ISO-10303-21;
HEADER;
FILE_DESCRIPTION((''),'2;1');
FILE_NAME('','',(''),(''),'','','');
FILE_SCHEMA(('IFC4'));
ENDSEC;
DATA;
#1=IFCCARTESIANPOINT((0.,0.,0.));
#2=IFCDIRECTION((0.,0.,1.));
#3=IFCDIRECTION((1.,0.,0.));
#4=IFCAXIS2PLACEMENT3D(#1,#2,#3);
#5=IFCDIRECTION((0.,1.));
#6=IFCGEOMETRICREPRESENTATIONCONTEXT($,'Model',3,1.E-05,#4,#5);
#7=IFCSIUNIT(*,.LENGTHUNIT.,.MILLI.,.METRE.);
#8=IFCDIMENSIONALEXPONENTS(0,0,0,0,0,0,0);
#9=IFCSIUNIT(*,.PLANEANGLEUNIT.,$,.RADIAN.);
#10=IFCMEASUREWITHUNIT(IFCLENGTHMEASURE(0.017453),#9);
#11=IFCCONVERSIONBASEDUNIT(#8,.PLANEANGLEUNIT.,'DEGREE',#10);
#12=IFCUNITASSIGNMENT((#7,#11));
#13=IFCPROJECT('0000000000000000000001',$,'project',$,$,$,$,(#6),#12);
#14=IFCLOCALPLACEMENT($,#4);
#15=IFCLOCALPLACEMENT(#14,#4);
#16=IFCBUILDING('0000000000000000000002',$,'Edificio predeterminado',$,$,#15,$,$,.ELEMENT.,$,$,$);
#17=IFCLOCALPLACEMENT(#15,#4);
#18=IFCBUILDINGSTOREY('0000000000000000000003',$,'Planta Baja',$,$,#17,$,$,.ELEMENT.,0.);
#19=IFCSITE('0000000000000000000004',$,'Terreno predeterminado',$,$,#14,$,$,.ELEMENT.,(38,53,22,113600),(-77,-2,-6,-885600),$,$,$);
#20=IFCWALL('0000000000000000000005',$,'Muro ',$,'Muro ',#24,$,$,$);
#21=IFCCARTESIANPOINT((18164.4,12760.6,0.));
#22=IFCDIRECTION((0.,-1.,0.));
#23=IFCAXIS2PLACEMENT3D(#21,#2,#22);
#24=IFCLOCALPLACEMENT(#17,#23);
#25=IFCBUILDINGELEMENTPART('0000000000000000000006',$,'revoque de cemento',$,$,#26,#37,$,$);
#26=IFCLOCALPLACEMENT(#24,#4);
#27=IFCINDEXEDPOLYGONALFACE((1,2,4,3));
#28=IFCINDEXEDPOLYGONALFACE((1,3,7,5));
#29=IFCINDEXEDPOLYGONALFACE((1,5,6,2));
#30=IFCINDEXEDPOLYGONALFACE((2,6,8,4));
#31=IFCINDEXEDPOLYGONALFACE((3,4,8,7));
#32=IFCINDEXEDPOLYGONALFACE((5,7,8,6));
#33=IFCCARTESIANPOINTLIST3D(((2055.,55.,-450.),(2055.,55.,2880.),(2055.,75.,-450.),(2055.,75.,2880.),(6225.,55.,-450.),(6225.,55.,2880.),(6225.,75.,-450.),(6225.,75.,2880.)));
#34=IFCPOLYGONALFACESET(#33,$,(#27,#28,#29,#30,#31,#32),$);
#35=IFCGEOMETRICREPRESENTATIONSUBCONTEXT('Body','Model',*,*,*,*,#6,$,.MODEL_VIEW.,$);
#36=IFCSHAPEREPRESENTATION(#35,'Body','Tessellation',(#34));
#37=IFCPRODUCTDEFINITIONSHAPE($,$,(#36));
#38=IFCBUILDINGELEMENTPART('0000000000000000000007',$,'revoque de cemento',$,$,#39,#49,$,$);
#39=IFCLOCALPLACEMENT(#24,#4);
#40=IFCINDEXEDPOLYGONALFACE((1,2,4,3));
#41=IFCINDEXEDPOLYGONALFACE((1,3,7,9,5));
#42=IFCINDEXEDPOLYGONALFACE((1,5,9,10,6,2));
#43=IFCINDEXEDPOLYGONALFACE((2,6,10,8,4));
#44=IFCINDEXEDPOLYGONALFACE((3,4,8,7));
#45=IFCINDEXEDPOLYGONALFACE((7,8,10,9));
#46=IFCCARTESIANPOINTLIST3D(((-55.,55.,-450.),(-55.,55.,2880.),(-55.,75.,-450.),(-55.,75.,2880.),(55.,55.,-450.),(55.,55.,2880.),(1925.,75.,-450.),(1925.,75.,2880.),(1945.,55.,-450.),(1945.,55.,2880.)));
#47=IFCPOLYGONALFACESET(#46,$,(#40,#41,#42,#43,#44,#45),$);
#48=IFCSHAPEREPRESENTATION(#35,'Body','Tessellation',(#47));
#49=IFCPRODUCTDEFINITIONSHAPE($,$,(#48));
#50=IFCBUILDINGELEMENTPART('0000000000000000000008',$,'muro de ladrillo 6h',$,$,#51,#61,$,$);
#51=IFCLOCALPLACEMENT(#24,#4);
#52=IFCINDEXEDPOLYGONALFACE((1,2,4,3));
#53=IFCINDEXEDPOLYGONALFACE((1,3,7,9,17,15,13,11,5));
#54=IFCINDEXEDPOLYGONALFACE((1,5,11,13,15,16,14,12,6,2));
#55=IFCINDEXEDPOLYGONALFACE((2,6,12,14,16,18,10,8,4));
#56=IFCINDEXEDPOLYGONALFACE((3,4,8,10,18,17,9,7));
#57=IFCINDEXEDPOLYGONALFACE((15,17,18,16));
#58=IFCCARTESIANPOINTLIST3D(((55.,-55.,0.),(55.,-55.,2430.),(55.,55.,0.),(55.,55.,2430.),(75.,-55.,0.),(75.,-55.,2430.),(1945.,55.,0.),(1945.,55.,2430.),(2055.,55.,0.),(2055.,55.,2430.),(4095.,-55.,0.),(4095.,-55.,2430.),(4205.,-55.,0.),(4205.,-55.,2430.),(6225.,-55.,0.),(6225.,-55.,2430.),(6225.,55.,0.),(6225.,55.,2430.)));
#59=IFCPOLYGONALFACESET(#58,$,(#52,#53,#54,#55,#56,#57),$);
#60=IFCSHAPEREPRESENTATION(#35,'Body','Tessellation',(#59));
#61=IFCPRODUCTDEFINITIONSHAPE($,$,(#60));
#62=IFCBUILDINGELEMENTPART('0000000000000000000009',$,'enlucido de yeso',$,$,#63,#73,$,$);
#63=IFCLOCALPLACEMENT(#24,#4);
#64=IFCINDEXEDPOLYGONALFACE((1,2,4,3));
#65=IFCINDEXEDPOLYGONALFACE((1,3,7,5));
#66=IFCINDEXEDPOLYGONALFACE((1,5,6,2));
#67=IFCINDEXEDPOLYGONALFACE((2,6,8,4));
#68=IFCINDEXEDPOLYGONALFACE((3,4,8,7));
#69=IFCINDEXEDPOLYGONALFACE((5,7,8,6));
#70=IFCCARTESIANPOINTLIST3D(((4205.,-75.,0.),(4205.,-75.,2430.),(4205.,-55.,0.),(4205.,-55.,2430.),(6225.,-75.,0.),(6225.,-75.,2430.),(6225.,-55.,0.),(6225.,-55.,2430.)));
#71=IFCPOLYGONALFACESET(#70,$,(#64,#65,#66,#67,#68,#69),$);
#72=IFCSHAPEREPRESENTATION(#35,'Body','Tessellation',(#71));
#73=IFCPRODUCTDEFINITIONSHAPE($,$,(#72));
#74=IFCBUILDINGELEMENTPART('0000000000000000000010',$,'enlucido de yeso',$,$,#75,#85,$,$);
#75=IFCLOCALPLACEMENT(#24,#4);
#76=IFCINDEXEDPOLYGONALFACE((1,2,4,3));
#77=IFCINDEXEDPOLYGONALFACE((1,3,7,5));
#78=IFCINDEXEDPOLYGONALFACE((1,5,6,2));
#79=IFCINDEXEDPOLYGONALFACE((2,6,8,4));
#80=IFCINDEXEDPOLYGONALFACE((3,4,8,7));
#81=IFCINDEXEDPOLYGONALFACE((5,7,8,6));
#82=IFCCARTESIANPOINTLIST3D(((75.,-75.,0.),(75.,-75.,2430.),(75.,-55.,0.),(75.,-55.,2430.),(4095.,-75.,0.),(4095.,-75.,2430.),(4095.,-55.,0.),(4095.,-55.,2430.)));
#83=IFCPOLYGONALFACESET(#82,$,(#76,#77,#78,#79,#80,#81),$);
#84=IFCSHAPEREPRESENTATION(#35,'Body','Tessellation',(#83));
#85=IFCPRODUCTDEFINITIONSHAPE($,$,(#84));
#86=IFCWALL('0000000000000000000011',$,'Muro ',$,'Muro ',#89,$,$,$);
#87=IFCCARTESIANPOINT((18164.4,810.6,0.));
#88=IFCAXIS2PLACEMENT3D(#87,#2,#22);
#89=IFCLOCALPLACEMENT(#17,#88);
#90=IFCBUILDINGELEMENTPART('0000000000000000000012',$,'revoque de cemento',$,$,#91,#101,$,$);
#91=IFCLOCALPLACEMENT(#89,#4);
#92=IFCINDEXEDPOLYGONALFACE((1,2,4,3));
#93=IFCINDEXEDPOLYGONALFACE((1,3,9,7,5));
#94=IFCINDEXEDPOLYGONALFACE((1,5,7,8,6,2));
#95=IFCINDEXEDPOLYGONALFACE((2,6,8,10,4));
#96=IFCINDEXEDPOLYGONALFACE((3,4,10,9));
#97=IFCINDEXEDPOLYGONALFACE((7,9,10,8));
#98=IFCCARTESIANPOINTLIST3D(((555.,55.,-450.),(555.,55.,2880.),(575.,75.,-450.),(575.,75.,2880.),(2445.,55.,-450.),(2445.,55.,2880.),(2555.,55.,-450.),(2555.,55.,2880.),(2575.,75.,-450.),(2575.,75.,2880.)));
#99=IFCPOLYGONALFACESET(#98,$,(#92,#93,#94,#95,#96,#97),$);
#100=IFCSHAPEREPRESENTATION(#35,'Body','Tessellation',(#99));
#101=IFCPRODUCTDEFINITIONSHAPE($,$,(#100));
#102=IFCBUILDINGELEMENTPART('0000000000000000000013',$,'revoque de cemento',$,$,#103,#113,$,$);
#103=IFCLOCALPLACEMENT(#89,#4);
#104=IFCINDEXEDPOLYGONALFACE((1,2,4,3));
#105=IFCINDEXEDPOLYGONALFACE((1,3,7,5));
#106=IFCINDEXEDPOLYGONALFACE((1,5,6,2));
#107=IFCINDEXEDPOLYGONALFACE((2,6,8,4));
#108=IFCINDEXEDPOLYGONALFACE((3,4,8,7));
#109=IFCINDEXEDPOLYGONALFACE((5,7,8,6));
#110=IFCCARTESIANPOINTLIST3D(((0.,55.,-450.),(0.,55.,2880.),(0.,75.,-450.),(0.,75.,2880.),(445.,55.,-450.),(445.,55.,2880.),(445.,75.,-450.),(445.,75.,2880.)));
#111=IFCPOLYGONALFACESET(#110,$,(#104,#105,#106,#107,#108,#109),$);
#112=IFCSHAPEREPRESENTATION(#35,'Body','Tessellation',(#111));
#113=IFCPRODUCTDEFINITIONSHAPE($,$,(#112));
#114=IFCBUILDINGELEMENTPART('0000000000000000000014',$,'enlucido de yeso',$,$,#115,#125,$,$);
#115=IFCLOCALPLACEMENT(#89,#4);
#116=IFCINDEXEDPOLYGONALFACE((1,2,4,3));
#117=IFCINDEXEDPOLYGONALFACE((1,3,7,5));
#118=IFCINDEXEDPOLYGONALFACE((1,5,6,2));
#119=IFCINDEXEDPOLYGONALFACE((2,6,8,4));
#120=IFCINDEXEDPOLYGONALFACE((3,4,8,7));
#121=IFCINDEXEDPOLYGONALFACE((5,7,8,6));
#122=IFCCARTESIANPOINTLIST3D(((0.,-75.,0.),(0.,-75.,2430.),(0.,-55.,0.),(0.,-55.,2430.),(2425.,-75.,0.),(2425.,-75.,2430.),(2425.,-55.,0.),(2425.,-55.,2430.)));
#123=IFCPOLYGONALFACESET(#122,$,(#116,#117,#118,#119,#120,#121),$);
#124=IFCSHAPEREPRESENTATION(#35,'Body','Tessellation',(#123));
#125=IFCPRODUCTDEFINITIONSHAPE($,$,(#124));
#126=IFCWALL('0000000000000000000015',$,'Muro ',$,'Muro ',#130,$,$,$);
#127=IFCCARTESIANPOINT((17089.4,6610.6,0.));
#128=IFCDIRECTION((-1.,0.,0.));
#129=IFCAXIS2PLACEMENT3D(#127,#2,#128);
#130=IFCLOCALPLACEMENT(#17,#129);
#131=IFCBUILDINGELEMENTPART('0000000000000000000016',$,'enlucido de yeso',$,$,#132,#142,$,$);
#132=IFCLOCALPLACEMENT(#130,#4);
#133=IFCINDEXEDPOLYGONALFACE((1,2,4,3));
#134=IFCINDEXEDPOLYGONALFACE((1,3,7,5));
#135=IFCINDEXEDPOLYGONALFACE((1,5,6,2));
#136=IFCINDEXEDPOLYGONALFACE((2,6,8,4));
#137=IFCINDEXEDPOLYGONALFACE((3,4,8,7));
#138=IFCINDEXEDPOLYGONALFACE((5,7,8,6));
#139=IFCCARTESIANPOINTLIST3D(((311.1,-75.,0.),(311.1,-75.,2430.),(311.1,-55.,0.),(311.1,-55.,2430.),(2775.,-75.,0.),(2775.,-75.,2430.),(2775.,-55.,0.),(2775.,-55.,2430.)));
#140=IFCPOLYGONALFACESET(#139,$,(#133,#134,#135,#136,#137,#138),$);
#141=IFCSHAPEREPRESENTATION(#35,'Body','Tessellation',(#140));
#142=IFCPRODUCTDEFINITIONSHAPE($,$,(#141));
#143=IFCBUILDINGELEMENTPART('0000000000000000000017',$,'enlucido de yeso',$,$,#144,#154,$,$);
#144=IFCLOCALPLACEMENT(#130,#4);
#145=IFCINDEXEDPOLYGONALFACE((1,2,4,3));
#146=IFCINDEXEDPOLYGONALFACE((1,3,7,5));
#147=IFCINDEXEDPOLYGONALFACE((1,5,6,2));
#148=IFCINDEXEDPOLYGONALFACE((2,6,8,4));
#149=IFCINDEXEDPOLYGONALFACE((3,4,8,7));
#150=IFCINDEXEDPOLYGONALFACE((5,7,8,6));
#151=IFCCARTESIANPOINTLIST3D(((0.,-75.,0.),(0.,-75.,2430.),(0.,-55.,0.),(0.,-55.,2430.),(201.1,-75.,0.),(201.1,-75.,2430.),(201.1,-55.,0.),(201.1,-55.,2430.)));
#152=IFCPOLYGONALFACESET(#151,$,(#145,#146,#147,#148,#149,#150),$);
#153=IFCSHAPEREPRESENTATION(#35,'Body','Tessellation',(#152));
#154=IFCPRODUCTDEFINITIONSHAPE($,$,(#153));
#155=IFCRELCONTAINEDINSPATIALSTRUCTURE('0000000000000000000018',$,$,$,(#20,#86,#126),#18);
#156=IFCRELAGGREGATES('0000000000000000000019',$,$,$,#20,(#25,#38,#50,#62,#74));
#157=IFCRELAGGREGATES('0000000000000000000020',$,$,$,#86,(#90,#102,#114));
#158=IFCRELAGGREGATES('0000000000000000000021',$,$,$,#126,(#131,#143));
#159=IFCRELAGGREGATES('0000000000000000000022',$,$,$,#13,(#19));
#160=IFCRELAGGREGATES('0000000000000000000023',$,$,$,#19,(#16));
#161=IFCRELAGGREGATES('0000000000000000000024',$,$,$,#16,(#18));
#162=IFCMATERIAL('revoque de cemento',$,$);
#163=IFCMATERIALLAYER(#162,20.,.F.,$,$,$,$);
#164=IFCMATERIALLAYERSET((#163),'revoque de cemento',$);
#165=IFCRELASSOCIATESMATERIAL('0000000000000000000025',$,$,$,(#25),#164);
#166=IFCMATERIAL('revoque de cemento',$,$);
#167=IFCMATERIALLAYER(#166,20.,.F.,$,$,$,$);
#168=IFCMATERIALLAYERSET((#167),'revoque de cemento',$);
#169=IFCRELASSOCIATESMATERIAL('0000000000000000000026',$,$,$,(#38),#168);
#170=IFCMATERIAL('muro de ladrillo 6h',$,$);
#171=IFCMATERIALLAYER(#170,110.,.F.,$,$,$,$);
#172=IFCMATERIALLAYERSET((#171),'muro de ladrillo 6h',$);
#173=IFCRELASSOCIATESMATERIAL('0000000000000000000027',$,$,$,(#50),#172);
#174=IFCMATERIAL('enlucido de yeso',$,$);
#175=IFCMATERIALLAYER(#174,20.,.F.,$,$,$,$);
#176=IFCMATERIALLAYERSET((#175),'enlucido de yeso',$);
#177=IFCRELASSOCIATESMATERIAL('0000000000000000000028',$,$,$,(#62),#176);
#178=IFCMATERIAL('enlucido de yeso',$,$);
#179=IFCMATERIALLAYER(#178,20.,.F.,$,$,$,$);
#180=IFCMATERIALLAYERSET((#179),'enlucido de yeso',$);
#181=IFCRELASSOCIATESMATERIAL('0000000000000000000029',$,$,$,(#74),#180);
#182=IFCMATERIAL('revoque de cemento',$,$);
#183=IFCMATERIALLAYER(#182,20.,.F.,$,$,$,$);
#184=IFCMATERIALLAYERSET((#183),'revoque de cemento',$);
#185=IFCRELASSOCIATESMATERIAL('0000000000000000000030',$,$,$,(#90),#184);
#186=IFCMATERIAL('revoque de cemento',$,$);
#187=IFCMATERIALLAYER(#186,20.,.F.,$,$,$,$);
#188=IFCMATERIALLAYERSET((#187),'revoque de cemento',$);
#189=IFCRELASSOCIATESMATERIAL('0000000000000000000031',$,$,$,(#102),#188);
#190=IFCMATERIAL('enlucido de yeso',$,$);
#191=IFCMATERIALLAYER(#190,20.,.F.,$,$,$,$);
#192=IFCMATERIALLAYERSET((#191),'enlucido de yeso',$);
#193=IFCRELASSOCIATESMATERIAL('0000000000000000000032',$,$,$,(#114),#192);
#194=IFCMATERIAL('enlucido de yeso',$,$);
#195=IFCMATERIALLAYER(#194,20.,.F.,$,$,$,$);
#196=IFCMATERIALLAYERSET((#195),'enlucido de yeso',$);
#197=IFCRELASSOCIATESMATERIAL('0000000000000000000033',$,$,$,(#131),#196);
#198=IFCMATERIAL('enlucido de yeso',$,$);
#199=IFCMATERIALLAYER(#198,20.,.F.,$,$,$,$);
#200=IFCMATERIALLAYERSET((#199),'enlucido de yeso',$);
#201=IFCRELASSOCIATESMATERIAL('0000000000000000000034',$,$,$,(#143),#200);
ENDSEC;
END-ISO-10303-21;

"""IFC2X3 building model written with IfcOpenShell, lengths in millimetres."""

from ifc_helpers import new_model, entity, si_unit, converted_unit, direction, frame, origin_with_axes, place, context, subcontext, project, spatial, polyline, outline, extrude, material, layer, layer_set, layer_usage, element, aggregate, save


model = new_model("IFC2X3")

# Units and contexts
model_context = context("Model", 3, precision=1e-05, world=origin_with_axes(), true_north=direction((0.0, 1.0)))
body_context = subcontext(model_context, "Body", "Model", "MODEL_VIEW")
ifc_project = project(units=[si_unit("LENGTHUNIT", "METRE", prefix="MILLI"), converted_unit("PLANEANGLEUNIT", "DEGREE", entity("IfcLengthMeasure", 0.017453), si_unit("PLANEANGLEUNIT", "RADIAN"), dimensions=[0, 0, 0, 0, 0, 0, 0])], contexts=[model_context])

# Site, building, storey
site_placement = place(None, origin_with_axes())
site = spatial("IfcSite", under=ifc_project, at=site_placement, Name="Terreno predeterminado", CompositionType="ELEMENT", RefLatitude=(38, 53, 22, 113600), RefLongitude=(-77, -2, -6, -885600))
building_placement = place(site_placement, origin_with_axes())
building = spatial("IfcBuilding", under=site, at=building_placement, Name="Edificio predeterminado", CompositionType="ELEMENT")
storey_placement = place(building_placement, origin_with_axes())
storey = spatial("IfcBuildingStorey", under=building, at=storey_placement, Name="Planta Baja", CompositionType="ELEMENT", Elevation=0.0)

# Walls, building element parts
wall_1_placement = place(storey_placement, frame((18164.4, 12760.6, 0.0), z_axis=(0.0, 0.0, 1.0), x_axis=(0.0, -1.0, 0.0)))
wall_1 = element("IfcWall", 1, at=wall_1_placement, inside=storey, Name="Muro ", ObjectType="Muro ")
ifc_material_1 = material(Name="revoque de cemento")
ifc_layer_1 = layer(ifc_material_1, 20.0, ventilated=False)
ifc_layer_set_1 = layer_set([ifc_layer_1], Name="revoque de cemento")
ifc_layer_usage_1 = layer_usage(ifc_layer_set_1, "AXIS2", "NEGATIVE", -75.0)
building_element_part_1_placement = place(wall_1_placement, origin_with_axes())
building_element_part_1 = element("IfcBuildingElementPart", 2, at=building_element_part_1_placement, material=ifc_layer_usage_1, Name="revoque de cemento", context=body_context, shape_type="SweptSolid", body=[
    extrude(outline(polyline([(6225.0, 75.0), (6225.0, 55.0), (2055.0, 55.0), (2055.0, 75.0), (6225.0, 75.0)])), frame((0.0, 0.0, -450.0), z_axis=(0.0, 0.0, 1.0), x_axis=(1.0, 0.0, 0.0)), (0.0, 0.0, 1.0), 3330.0),
])
ifc_material_2 = material(Name="revoque de cemento")
ifc_layer_2 = layer(ifc_material_2, 20.0, ventilated=False)
ifc_layer_set_2 = layer_set([ifc_layer_2], Name="revoque de cemento")
ifc_layer_usage_2 = layer_usage(ifc_layer_set_2, "AXIS2", "NEGATIVE", -75.0)
building_element_part_2_placement = place(wall_1_placement, origin_with_axes())
building_element_part_2 = element("IfcBuildingElementPart", 3, at=building_element_part_2_placement, material=ifc_layer_usage_2, Name="revoque de cemento", context=body_context, shape_type="SweptSolid", body=[
    extrude(outline(polyline([(1925.0, 75.0), (1945.0, 55.0), (55.0, 55.0), (-55.0, 55.0), (-55.0, 75.0), (1925.0, 75.0)])), frame((0.0, 0.0, -450.0), z_axis=(0.0, 0.0, 1.0), x_axis=(1.0, 0.0, 0.0)), (0.0, 0.0, 1.0), 3330.0),
])
ifc_material_3 = material(Name="muro de ladrillo 6h")
ifc_layer_3 = layer(ifc_material_3, 110.0, ventilated=False)
ifc_layer_set_3 = layer_set([ifc_layer_3], Name="muro de ladrillo 6h")
ifc_layer_usage_3 = layer_usage(ifc_layer_set_3, "AXIS2", "NEGATIVE", -55.0)
building_element_part_3_placement = place(wall_1_placement, origin_with_axes())
building_element_part_3 = element("IfcBuildingElementPart", 4, at=building_element_part_3_placement, material=ifc_layer_usage_3, Name="muro de ladrillo 6h", context=body_context, shape_type="SweptSolid", body=[
    extrude(outline(polyline([(6225.0, 55.0), (6225.0, -55.0), (4205.0, -55.0), (4095.0, -55.0), (75.0, -55.0), (55.0, -55.0), (55.0, 55.0), (1945.0, 55.0), (2055.0, 55.0), (6225.0, 55.0)])), origin_with_axes(), (0.0, 0.0, 1.0), 2430.0),
])
ifc_material_4 = material(Name="enlucido de yeso")
ifc_layer_4 = layer(ifc_material_4, 20.0, ventilated=False)
ifc_layer_set_4 = layer_set([ifc_layer_4], Name="enlucido de yeso")
ifc_layer_usage_4 = layer_usage(ifc_layer_set_4, "AXIS2", "NEGATIVE", 55.0)
building_element_part_4_placement = place(wall_1_placement, origin_with_axes())
building_element_part_4 = element("IfcBuildingElementPart", 5, at=building_element_part_4_placement, material=ifc_layer_usage_4, Name="enlucido de yeso", context=body_context, shape_type="SweptSolid", body=[
    extrude(outline(polyline([(6225.0, -55.0), (6225.0, -75.0), (4205.0, -75.0), (4205.0, -55.0), (6225.0, -55.0)])), origin_with_axes(), (0.0, 0.0, 1.0), 2430.0),
])
ifc_material_5 = material(Name="enlucido de yeso")
ifc_layer_5 = layer(ifc_material_5, 20.0, ventilated=False)
ifc_layer_set_5 = layer_set([ifc_layer_5], Name="enlucido de yeso")
ifc_layer_usage_5 = layer_usage(ifc_layer_set_5, "AXIS2", "NEGATIVE", 55.0)
building_element_part_5_placement = place(wall_1_placement, origin_with_axes())
building_element_part_5 = element("IfcBuildingElementPart", 6, at=building_element_part_5_placement, material=ifc_layer_usage_5, Name="enlucido de yeso", context=body_context, shape_type="SweptSolid", body=[
    extrude(outline(polyline([(4095.0, -55.0), (4095.0, -75.0), (75.0, -75.0), (75.0, -55.0), (4095.0, -55.0)])), origin_with_axes(), (0.0, 0.0, 1.0), 2430.0),
])
aggregate(wall_1, [building_element_part_1, building_element_part_2, building_element_part_3, building_element_part_4, building_element_part_5])
wall_2_placement = place(storey_placement, frame((18164.4, 810.6, 0.0), z_axis=(0.0, 0.0, 1.0), x_axis=(0.0, -1.0, 0.0)))
wall_2 = element("IfcWall", 7, at=wall_2_placement, inside=storey, Name="Muro ", ObjectType="Muro ")
ifc_material_6 = material(Name="revoque de cemento")
ifc_layer_6 = layer(ifc_material_6, 20.0, ventilated=False)
ifc_layer_set_6 = layer_set([ifc_layer_6], Name="revoque de cemento")
ifc_layer_usage_6 = layer_usage(ifc_layer_set_6, "AXIS2", "NEGATIVE", -75.0)
building_element_part_6_placement = place(wall_2_placement, origin_with_axes())
building_element_part_6 = element("IfcBuildingElementPart", 8, at=building_element_part_6_placement, material=ifc_layer_usage_6, Name="revoque de cemento", context=body_context, shape_type="SweptSolid", body=[
    extrude(outline(polyline([(2575.0, 75.0), (2555.0, 55.0), (2445.0, 55.0), (555.0, 55.0), (575.0, 75.0), (2575.0, 75.0)])), frame((0.0, 0.0, -450.0), z_axis=(0.0, 0.0, 1.0), x_axis=(1.0, 0.0, 0.0)), (0.0, 0.0, 1.0), 3330.0),
])
ifc_material_7 = material(Name="revoque de cemento")
ifc_layer_7 = layer(ifc_material_7, 20.0, ventilated=False)
ifc_layer_set_7 = layer_set([ifc_layer_7], Name="revoque de cemento")
ifc_layer_usage_7 = layer_usage(ifc_layer_set_7, "AXIS2", "NEGATIVE", -75.0)
building_element_part_7_placement = place(wall_2_placement, origin_with_axes())
building_element_part_7 = element("IfcBuildingElementPart", 9, at=building_element_part_7_placement, material=ifc_layer_usage_7, Name="revoque de cemento", context=body_context, shape_type="SweptSolid", body=[
    extrude(outline(polyline([(445.0, 75.0), (445.0, 55.0), (0.0, 55.0), (0.0, 75.0), (445.0, 75.0)])), frame((0.0, 0.0, -450.0), z_axis=(0.0, 0.0, 1.0), x_axis=(1.0, 0.0, 0.0)), (0.0, 0.0, 1.0), 3330.0),
])
ifc_material_8 = material(Name="enlucido de yeso")
ifc_layer_8 = layer(ifc_material_8, 20.0, ventilated=False)
ifc_layer_set_8 = layer_set([ifc_layer_8], Name="enlucido de yeso")
ifc_layer_usage_8 = layer_usage(ifc_layer_set_8, "AXIS2", "NEGATIVE", 55.0)
building_element_part_8_placement = place(wall_2_placement, origin_with_axes())
building_element_part_8 = element("IfcBuildingElementPart", 10, at=building_element_part_8_placement, material=ifc_layer_usage_8, Name="enlucido de yeso", context=body_context, shape_type="SweptSolid", body=[
    extrude(outline(polyline([(2425.0, -55.0), (2425.0, -75.0), (0.0, -75.0), (0.0, -55.0), (2425.0, -55.0)])), origin_with_axes(), (0.0, 0.0, 1.0), 2430.0),
])
aggregate(wall_2, [building_element_part_6, building_element_part_7, building_element_part_8])
wall_3_placement = place(storey_placement, frame((17089.4, 6610.6, 0.0), z_axis=(0.0, 0.0, 1.0), x_axis=(-1.0, 0.0, 0.0)))
wall_3 = element("IfcWall", 11, at=wall_3_placement, inside=storey, Name="Muro ", ObjectType="Muro ")
ifc_material_9 = material(Name="enlucido de yeso")
ifc_layer_9 = layer(ifc_material_9, 20.0, ventilated=False)
ifc_layer_set_9 = layer_set([ifc_layer_9], Name="enlucido de yeso")
ifc_layer_usage_9 = layer_usage(ifc_layer_set_9, "AXIS2", "NEGATIVE", 55.0)
building_element_part_9_placement = place(wall_3_placement, origin_with_axes())
building_element_part_9 = element("IfcBuildingElementPart", 12, at=building_element_part_9_placement, material=ifc_layer_usage_9, Name="enlucido de yeso", context=body_context, shape_type="SweptSolid", body=[
    extrude(outline(polyline([(2775.0, -55.0), (2775.0, -75.0), (311.1, -75.0), (311.1, -55.0), (2775.0, -55.0)])), origin_with_axes(), (0.0, 0.0, 1.0), 2430.0),
])
ifc_material_10 = material(Name="enlucido de yeso")
ifc_layer_10 = layer(ifc_material_10, 20.0, ventilated=False)
ifc_layer_set_10 = layer_set([ifc_layer_10], Name="enlucido de yeso")
ifc_layer_usage_10 = layer_usage(ifc_layer_set_10, "AXIS2", "NEGATIVE", 55.0)
building_element_part_10_placement = place(wall_3_placement, origin_with_axes())
building_element_part_10 = element("IfcBuildingElementPart", 13, at=building_element_part_10_placement, material=ifc_layer_usage_10, Name="enlucido de yeso", context=body_context, shape_type="SweptSolid", body=[
    extrude(outline(polyline([(201.1, -55.0), (201.1, -75.0), (0.0, -75.0), (0.0, -55.0), (201.1, -55.0)])), origin_with_axes(), (0.0, 0.0, 1.0), 2430.0),
])
aggregate(wall_3, [building_element_part_9, building_element_part_10])

save(model, "model.ifc")
